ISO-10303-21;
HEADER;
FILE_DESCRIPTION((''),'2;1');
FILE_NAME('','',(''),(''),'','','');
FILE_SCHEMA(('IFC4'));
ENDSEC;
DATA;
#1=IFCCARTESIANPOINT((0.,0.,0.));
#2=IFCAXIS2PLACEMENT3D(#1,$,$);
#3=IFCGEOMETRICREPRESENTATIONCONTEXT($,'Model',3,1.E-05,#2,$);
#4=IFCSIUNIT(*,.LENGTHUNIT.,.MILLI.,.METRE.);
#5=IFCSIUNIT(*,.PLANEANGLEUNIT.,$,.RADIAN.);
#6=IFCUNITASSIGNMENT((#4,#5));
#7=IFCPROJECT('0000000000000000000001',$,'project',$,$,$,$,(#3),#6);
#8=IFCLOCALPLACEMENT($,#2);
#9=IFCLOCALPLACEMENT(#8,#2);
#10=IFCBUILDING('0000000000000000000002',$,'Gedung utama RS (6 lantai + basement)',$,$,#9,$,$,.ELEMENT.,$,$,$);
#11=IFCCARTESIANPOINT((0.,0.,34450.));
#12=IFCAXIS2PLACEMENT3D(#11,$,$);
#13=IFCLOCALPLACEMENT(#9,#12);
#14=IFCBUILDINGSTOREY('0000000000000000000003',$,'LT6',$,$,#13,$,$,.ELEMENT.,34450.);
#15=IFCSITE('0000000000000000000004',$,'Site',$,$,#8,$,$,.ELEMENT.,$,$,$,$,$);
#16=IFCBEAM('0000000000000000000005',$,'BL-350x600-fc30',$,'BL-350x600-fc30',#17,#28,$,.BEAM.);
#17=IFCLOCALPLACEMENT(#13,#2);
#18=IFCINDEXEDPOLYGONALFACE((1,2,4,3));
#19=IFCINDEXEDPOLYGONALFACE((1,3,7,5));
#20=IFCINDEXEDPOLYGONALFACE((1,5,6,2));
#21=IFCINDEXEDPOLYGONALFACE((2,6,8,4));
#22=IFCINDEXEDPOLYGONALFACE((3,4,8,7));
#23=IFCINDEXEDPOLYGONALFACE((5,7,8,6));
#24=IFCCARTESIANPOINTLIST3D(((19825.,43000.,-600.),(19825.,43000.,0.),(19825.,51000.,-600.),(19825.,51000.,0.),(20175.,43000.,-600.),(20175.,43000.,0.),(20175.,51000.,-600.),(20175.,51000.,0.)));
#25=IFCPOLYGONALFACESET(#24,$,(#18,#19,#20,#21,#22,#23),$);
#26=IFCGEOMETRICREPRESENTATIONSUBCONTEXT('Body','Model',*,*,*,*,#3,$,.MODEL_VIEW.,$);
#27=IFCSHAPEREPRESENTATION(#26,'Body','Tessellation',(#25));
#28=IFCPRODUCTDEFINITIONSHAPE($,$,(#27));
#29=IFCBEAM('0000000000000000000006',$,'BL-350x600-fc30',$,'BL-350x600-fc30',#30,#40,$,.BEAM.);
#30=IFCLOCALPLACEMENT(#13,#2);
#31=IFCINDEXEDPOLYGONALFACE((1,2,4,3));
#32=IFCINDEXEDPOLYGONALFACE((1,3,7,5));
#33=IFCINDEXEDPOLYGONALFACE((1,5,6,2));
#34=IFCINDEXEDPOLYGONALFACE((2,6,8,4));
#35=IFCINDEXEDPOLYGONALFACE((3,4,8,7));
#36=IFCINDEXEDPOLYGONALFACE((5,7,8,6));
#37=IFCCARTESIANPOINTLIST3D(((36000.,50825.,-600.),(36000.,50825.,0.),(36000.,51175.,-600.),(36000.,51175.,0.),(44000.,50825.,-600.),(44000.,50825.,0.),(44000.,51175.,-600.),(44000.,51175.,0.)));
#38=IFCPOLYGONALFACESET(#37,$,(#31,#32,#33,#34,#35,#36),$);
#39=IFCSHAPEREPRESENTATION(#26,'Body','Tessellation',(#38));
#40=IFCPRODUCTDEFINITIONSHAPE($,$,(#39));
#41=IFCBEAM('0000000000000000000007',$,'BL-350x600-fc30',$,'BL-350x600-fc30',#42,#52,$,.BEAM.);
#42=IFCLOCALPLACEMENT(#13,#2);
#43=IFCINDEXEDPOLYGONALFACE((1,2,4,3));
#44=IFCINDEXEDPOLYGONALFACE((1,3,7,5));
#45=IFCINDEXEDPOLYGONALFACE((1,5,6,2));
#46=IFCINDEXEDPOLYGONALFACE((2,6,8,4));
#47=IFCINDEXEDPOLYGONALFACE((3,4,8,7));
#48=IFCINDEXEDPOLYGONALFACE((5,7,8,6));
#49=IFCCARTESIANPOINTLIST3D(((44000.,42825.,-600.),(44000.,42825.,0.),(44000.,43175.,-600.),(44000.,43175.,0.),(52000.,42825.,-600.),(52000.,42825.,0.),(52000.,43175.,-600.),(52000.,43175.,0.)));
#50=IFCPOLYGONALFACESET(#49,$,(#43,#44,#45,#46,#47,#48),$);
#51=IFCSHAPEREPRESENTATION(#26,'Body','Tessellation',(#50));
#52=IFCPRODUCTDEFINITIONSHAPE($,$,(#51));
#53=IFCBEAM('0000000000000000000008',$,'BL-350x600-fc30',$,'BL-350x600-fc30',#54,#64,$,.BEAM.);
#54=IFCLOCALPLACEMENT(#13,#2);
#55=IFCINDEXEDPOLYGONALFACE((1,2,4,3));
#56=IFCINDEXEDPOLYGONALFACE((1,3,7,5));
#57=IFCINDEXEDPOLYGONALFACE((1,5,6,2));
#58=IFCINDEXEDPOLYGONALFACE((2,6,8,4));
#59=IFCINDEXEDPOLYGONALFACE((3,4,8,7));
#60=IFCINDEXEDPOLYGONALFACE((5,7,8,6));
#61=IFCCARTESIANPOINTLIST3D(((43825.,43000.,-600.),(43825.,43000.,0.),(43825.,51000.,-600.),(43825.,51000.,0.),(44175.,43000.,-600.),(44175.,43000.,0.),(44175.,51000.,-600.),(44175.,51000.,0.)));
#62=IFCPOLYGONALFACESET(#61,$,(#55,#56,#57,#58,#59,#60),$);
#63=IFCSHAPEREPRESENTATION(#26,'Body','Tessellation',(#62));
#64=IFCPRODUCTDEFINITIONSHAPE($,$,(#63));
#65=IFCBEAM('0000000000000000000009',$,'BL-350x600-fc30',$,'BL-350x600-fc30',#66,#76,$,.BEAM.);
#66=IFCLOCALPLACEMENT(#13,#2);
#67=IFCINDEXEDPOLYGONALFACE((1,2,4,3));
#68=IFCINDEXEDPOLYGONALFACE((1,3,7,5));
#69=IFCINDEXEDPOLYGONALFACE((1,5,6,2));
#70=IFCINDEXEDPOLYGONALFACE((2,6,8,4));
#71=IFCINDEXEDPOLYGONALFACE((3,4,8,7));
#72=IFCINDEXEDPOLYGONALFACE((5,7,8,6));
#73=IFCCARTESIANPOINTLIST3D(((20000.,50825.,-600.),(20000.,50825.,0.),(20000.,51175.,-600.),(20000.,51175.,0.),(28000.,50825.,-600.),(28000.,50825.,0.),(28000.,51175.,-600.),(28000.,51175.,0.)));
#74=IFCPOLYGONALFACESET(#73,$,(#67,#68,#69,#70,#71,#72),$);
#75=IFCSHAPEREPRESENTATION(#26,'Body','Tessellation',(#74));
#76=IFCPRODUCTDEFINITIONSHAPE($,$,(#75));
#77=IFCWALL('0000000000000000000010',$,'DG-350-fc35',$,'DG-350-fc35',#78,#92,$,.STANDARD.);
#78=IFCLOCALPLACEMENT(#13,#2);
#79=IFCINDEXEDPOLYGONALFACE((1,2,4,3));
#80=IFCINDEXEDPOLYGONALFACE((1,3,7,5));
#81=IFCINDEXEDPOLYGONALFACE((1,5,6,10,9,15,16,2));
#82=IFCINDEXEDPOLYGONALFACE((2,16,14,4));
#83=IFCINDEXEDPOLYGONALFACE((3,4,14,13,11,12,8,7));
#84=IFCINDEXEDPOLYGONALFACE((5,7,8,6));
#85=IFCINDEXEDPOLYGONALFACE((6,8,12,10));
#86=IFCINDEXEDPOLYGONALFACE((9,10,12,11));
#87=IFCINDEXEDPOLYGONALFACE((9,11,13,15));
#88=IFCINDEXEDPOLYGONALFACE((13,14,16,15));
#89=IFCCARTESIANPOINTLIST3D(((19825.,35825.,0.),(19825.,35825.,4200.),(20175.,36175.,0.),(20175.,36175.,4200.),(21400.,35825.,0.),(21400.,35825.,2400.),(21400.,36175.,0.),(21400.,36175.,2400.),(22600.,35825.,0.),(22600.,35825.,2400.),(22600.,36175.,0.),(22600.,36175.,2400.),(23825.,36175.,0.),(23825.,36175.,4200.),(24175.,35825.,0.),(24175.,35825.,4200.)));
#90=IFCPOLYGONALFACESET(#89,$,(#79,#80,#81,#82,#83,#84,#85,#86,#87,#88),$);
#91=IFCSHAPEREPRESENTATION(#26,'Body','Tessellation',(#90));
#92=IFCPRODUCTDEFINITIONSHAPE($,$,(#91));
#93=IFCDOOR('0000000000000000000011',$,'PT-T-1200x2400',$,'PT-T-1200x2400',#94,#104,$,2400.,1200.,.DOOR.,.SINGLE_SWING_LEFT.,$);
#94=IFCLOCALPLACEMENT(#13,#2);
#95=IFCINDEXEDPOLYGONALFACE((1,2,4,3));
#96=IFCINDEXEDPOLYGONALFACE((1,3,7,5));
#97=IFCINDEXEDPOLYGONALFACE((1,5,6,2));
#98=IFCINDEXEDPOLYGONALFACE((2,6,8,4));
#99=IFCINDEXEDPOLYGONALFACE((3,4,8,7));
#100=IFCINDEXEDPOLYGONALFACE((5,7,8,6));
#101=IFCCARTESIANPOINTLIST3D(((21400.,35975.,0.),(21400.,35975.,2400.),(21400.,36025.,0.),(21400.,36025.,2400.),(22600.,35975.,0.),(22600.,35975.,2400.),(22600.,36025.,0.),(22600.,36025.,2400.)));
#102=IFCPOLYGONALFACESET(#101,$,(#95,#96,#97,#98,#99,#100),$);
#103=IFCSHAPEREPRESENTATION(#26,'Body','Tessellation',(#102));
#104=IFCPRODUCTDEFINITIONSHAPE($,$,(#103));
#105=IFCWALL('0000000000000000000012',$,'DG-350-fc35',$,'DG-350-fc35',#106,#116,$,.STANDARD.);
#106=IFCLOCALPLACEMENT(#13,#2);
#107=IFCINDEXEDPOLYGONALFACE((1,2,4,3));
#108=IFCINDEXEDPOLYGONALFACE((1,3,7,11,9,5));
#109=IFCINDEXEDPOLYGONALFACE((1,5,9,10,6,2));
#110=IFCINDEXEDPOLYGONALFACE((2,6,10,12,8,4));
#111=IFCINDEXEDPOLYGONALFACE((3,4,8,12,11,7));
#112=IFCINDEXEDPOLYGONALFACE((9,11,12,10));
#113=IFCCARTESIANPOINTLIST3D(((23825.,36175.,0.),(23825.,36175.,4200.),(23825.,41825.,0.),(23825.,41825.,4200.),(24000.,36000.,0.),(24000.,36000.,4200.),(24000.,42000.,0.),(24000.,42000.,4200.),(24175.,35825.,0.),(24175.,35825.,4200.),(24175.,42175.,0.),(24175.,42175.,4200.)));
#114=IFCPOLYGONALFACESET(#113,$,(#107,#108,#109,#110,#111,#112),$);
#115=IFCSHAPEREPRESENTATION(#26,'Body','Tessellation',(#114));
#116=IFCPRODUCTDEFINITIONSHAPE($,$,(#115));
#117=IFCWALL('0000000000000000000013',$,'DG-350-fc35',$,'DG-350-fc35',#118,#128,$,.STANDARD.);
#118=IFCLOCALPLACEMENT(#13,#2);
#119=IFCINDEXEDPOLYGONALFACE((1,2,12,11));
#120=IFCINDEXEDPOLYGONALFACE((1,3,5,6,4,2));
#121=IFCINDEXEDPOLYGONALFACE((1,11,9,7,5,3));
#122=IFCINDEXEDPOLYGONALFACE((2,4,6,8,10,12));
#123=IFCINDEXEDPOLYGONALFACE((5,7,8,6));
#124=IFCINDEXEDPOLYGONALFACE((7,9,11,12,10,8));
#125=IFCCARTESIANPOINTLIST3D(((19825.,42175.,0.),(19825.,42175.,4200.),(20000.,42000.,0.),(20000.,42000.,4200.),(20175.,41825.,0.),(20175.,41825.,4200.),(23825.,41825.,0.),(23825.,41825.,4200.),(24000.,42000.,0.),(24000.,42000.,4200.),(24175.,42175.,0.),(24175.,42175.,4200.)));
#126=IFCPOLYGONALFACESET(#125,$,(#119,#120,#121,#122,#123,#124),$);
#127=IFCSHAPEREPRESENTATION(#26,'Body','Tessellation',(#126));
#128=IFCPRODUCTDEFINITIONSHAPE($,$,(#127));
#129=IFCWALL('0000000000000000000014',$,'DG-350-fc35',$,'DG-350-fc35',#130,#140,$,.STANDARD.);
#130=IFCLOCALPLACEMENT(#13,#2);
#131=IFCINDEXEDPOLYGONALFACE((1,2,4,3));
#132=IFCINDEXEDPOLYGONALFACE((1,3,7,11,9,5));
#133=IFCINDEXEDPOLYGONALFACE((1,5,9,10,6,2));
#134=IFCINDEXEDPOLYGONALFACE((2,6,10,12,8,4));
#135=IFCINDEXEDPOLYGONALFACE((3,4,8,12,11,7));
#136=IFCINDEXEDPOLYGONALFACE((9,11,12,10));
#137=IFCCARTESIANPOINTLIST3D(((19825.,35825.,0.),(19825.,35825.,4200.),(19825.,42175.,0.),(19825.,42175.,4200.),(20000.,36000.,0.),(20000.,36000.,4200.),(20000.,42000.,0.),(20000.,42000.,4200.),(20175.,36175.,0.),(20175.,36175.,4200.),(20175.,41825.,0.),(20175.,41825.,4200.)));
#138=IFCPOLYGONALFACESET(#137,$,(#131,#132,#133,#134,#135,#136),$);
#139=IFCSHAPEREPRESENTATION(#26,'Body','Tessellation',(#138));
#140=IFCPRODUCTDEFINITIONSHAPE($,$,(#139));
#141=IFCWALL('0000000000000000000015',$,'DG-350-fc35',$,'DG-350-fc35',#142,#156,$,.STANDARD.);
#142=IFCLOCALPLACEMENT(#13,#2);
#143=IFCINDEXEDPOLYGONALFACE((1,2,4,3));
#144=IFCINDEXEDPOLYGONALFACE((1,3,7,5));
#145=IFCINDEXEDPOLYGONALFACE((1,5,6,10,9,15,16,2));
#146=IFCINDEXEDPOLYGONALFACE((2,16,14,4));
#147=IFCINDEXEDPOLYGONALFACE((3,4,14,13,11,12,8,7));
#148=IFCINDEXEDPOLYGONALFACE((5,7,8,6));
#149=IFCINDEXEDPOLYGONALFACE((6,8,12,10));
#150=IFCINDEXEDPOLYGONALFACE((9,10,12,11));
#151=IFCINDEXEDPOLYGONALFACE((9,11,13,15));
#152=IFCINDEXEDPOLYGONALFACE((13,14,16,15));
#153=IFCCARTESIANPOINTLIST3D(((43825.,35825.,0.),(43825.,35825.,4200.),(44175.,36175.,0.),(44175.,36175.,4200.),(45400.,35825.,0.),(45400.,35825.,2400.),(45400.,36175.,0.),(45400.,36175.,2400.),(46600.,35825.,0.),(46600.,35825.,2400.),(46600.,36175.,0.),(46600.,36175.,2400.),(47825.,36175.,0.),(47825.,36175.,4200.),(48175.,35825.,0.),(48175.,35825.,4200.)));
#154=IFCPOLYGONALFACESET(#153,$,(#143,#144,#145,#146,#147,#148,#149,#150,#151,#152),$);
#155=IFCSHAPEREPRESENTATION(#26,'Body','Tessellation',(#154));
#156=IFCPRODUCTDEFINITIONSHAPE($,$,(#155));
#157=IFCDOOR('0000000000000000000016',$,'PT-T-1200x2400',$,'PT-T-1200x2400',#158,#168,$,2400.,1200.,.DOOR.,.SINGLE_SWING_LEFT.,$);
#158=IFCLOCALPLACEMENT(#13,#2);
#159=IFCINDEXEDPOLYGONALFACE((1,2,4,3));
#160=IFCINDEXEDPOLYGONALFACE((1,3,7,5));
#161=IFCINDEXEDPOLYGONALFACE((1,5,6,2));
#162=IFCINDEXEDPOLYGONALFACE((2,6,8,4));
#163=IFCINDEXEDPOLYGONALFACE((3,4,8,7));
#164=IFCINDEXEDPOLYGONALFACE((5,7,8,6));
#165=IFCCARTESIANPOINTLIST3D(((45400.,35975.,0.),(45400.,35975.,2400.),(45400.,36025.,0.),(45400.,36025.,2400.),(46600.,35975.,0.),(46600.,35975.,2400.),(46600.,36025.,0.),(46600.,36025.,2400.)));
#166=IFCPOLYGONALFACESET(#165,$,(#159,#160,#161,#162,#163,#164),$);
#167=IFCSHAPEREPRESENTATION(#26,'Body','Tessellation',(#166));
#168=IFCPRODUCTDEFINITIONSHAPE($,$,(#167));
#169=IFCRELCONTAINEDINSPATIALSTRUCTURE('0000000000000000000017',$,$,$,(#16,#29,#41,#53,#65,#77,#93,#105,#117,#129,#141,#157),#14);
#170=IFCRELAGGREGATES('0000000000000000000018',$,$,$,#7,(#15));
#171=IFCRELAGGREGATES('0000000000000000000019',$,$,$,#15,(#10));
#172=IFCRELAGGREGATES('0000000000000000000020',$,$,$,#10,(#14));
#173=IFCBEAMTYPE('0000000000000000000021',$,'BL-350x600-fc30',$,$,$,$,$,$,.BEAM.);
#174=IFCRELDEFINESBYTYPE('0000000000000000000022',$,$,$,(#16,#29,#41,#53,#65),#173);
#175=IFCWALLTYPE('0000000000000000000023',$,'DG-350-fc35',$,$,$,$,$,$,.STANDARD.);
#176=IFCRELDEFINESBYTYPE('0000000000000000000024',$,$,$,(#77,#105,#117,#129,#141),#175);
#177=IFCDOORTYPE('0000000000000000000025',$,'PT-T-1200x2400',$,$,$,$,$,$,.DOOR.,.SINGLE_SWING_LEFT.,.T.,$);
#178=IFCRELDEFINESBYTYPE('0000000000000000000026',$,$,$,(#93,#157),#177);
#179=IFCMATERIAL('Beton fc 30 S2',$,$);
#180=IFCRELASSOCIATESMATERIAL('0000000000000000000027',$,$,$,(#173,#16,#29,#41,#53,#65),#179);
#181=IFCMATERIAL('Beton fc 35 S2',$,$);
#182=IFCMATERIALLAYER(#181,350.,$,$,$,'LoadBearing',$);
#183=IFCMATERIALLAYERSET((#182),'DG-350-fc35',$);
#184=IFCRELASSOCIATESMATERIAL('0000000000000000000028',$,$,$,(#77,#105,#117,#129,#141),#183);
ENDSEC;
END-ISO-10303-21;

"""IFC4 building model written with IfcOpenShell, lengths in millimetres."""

from ifc_helpers import new_model, si_unit, frame, frame_2d, origin, origin_2d, place, context, subcontext, project, spatial, polyline, rectangle, outline, extrude, material, layer, layer_set, layer_usage, material_profile, profile_set, profile_usage, type_object, element, fill, save


model = new_model("IFC4")

# Units and contexts
model_context = context("Model", 3, precision=1e-05, world=origin())
body_context = subcontext(model_context, "Body", "Model", "MODEL_VIEW")
ifc_project = project(units=[si_unit("LENGTHUNIT", "METRE", prefix="MILLI"), si_unit("PLANEANGLEUNIT", "RADIAN")], contexts=[model_context])

# Site, building, storey
site_placement = place(None, origin())
site = spatial("IfcSite", under=ifc_project, at=site_placement, Name="Site", CompositionType="ELEMENT")
building_placement = place(site_placement, origin())
building = spatial("IfcBuilding", under=site, at=building_placement, Name="Gedung utama RS (6 lantai + basement)", CompositionType="ELEMENT")
storey_placement = place(building_placement, frame((0.0, 0.0, 34450.0)))
storey = spatial("IfcBuildingStorey", under=building, at=storey_placement, Name="LT6", CompositionType="ELEMENT", Elevation=34450.0)

# Beams
ifc_material_1 = material(Name="Beton fc 30 S2")
ifc_material_profile_1 = material_profile(ifc_material_1, rectangle(XDim=350.0, YDim=600.0, at=origin_2d()), Name="BL-350x600-fc30")
ifc_profile_set_1 = profile_set([ifc_material_profile_1], Name="BL-350x600-fc30")
ifc_profile_usage_1 = profile_usage(ifc_profile_set_1, cardinal=8)
beam_type = type_object("IfcBeamType", Name="BL-350x600-fc30", PredefinedType="BEAM", material=ifc_profile_set_1)
beam_1_placement = place(storey_placement, frame((20000.0, 43000.0, -300.0)))
element("IfcBeam", 1, at=beam_1_placement, inside=storey, type_object=beam_type, material=ifc_profile_usage_1, Name="BL-350x600-fc30", ObjectType="BL-350x600-fc30", PredefinedType="BEAM", context=body_context, shape_type="SweptSolid", body=[
    extrude(rectangle(XDim=350.0, YDim=600.0, at=origin_2d()), frame((0.0, 0.0, 0.0), z_axis=(0.0, 1.0, 0.0), x_axis=(-1.0, 0.0, 0.0)), (0.0, 0.0, 1.0), 8000.0),
])
for number, where, name in (
    (2, (36000.0, 51000.0, -300.0), "BL-350x600-fc30"),
    (3, (44000.0, 43000.0, -300.0), "BL-350x600-fc30"),
):
    element("IfcBeam", number, at=place(storey_placement, frame(where)), inside=storey, type_object=beam_type, material=ifc_profile_usage_1, Name=name, ObjectType="BL-350x600-fc30", PredefinedType="BEAM", context=body_context, shape_type="SweptSolid", body=[
        extrude(rectangle(XDim=350.0, YDim=600.0, at=origin_2d()), frame((0.0, 0.0, 0.0), z_axis=(1.0, 0.0, 0.0), x_axis=(0.0, 1.0, 0.0)), (0.0, 0.0, 1.0), 8000.0),
    ])
beam_2_placement = place(storey_placement, frame((44000.0, 43000.0, -300.0)))
element("IfcBeam", 4, at=beam_2_placement, inside=storey, type_object=beam_type, material=ifc_profile_usage_1, Name="BL-350x600-fc30", ObjectType="BL-350x600-fc30", PredefinedType="BEAM", context=body_context, shape_type="SweptSolid", body=[
    extrude(rectangle(XDim=350.0, YDim=600.0, at=origin_2d()), frame((0.0, 0.0, 0.0), z_axis=(0.0, 1.0, 0.0), x_axis=(-1.0, 0.0, 0.0)), (0.0, 0.0, 1.0), 8000.0),
])
beam_3_placement = place(storey_placement, frame((20000.0, 51000.0, -300.0)))
element("IfcBeam", 5, at=beam_3_placement, inside=storey, type_object=beam_type, material=ifc_profile_usage_1, Name="BL-350x600-fc30", ObjectType="BL-350x600-fc30", PredefinedType="BEAM", context=body_context, shape_type="SweptSolid", body=[
    extrude(rectangle(XDim=350.0, YDim=600.0, at=origin_2d()), frame((0.0, 0.0, 0.0), z_axis=(1.0, 0.0, 0.0), x_axis=(0.0, 1.0, 0.0)), (0.0, 0.0, 1.0), 8000.0),
])

# Wall, opening, door
ifc_material_2 = material(Name="Beton fc 35 S2")
ifc_layer = layer(ifc_material_2, 350.0, Category="LoadBearing")
ifc_layer_set = layer_set([ifc_layer], Name="DG-350-fc35")
ifc_layer_usage = layer_usage(ifc_layer_set, "AXIS2", "NEGATIVE", 175.0)
wall_type = type_object("IfcWallType", Name="DG-350-fc35", PredefinedType="STANDARD")
wall_1_placement = place(storey_placement, frame((20000.0, 36000.0, 0.0), z_axis=(0.0, 0.0, 1.0), x_axis=(1.0, 0.0, 0.0)))
wall_1 = element("IfcWall", 6, at=wall_1_placement, inside=storey, type_object=wall_type, material=ifc_layer_usage, Name="DG-350-fc35", ObjectType="DG-350-fc35", PredefinedType="STANDARD", context=body_context, shape_type="SweptSolid", body=[
    extrude(outline(polyline([(-175.0, -175.0), (0.0, 0.0), (175.0, 175.0), (3825.0, 175.0), (4000.0, 0.0), (4175.0, -175.0), (-175.0, -175.0)])), origin(), (0.0, 0.0, 1.0), 4200.0),
])
opening_1_placement = place(wall_1_placement, frame((1400.0, 0.0, 0.0), z_axis=(0.0, 0.0, 1.0), x_axis=(1.0, 0.0, 0.0)))
opening_1 = element("IfcOpeningElement", 7, at=opening_1_placement, cuts=wall_1, PredefinedType="OPENING", context=body_context, shape_type="SweptSolid", body=[
    extrude(rectangle(XDim=1200.0, YDim=370.0, at=frame_2d((600.0, 0.0))), origin(), (0.0, 0.0, 1.0), 2400.0),
])
door_type = type_object("IfcDoorType", Name="PT-T-1200x2400", OperationType="SINGLE_SWING_LEFT", ParameterTakesPrecedence=True, PredefinedType="DOOR")
door_1_placement = place(opening_1_placement, origin())
door_1 = element("IfcDoor", 8, at=door_1_placement, inside=storey, type_object=door_type, Name="PT-T-1200x2400", ObjectType="PT-T-1200x2400", OperationType="SINGLE_SWING_LEFT", OverallHeight=2400.0, OverallWidth=1200.0, PredefinedType="DOOR", context=body_context, shape_type="SweptSolid", body=[
    extrude(rectangle(XDim=1200.0, YDim=50.0, at=frame_2d((600.0, 0.0))), origin(), (0.0, 0.0, 1.0), 2400.0),
])
fill(opening_1, door_1)

# Walls
wall_2_placement = place(storey_placement, frame((24000.0, 36000.0, 0.0), z_axis=(0.0, 0.0, 1.0), x_axis=(0.0, 1.0, 0.0)))
element("IfcWall", 9, at=wall_2_placement, inside=storey, type_object=wall_type, material=ifc_layer_usage, Name="DG-350-fc35", ObjectType="DG-350-fc35", PredefinedType="STANDARD", context=body_context, shape_type="SweptSolid", body=[
    extrude(outline(polyline([(-175.0, -175.0), (0.0, 0.0), (175.0, 175.0), (5825.0, 175.0), (6000.0, 0.0), (6175.0, -175.0), (-175.0, -175.0)])), origin(), (0.0, 0.0, 1.0), 4200.0),
])
wall_3_placement = place(storey_placement, frame((24000.0, 42000.0, 0.0), z_axis=(0.0, 0.0, 1.0), x_axis=(-1.0, 0.0, 0.0)))
element("IfcWall", 10, at=wall_3_placement, inside=storey, type_object=wall_type, material=ifc_layer_usage, Name="DG-350-fc35", ObjectType="DG-350-fc35", PredefinedType="STANDARD", context=body_context, shape_type="SweptSolid", body=[
    extrude(outline(polyline([(-175.0, -175.0), (0.0, 0.0), (175.0, 175.0), (3825.0, 175.0), (4000.0, 0.0), (4175.0, -175.0), (-175.0, -175.0)])), origin(), (0.0, 0.0, 1.0), 4200.0),
])
wall_4_placement = place(storey_placement, frame((20000.0, 42000.0, 0.0), z_axis=(0.0, 0.0, 1.0), x_axis=(0.0, -1.0, 0.0)))
element("IfcWall", 11, at=wall_4_placement, inside=storey, type_object=wall_type, material=ifc_layer_usage, Name="DG-350-fc35", ObjectType="DG-350-fc35", PredefinedType="STANDARD", context=body_context, shape_type="SweptSolid", body=[
    extrude(outline(polyline([(-175.0, -175.0), (0.0, 0.0), (175.0, 175.0), (5825.0, 175.0), (6000.0, 0.0), (6175.0, -175.0), (-175.0, -175.0)])), origin(), (0.0, 0.0, 1.0), 4200.0),
])

# Wall, opening, door
wall_5_placement = place(storey_placement, frame((44000.0, 36000.0, 0.0), z_axis=(0.0, 0.0, 1.0), x_axis=(1.0, 0.0, 0.0)))
wall_5 = element("IfcWall", 12, at=wall_5_placement, inside=storey, type_object=wall_type, material=ifc_layer_usage, Name="DG-350-fc35", ObjectType="DG-350-fc35", PredefinedType="STANDARD", context=body_context, shape_type="SweptSolid", body=[
    extrude(outline(polyline([(-175.0, -175.0), (0.0, 0.0), (175.0, 175.0), (3825.0, 175.0), (4000.0, 0.0), (4175.0, -175.0), (-175.0, -175.0)])), origin(), (0.0, 0.0, 1.0), 4200.0),
])
opening_2_placement = place(wall_5_placement, frame((1400.0, 0.0, 0.0), z_axis=(0.0, 0.0, 1.0), x_axis=(1.0, 0.0, 0.0)))
opening_2 = element("IfcOpeningElement", 13, at=opening_2_placement, cuts=wall_5, PredefinedType="OPENING", context=body_context, shape_type="SweptSolid", body=[
    extrude(rectangle(XDim=1200.0, YDim=370.0, at=frame_2d((600.0, 0.0))), origin(), (0.0, 0.0, 1.0), 2400.0),
])
door_2_placement = place(opening_2_placement, origin())
door_2 = element("IfcDoor", 14, at=door_2_placement, inside=storey, type_object=door_type, Name="PT-T-1200x2400", ObjectType="PT-T-1200x2400", OperationType="SINGLE_SWING_LEFT", OverallHeight=2400.0, OverallWidth=1200.0, PredefinedType="DOOR", context=body_context, shape_type="SweptSolid", body=[
    extrude(rectangle(XDim=1200.0, YDim=50.0, at=frame_2d((600.0, 0.0))), origin(), (0.0, 0.0, 1.0), 2400.0),
])
fill(opening_2, door_2)

save(model, "model.ifc")
